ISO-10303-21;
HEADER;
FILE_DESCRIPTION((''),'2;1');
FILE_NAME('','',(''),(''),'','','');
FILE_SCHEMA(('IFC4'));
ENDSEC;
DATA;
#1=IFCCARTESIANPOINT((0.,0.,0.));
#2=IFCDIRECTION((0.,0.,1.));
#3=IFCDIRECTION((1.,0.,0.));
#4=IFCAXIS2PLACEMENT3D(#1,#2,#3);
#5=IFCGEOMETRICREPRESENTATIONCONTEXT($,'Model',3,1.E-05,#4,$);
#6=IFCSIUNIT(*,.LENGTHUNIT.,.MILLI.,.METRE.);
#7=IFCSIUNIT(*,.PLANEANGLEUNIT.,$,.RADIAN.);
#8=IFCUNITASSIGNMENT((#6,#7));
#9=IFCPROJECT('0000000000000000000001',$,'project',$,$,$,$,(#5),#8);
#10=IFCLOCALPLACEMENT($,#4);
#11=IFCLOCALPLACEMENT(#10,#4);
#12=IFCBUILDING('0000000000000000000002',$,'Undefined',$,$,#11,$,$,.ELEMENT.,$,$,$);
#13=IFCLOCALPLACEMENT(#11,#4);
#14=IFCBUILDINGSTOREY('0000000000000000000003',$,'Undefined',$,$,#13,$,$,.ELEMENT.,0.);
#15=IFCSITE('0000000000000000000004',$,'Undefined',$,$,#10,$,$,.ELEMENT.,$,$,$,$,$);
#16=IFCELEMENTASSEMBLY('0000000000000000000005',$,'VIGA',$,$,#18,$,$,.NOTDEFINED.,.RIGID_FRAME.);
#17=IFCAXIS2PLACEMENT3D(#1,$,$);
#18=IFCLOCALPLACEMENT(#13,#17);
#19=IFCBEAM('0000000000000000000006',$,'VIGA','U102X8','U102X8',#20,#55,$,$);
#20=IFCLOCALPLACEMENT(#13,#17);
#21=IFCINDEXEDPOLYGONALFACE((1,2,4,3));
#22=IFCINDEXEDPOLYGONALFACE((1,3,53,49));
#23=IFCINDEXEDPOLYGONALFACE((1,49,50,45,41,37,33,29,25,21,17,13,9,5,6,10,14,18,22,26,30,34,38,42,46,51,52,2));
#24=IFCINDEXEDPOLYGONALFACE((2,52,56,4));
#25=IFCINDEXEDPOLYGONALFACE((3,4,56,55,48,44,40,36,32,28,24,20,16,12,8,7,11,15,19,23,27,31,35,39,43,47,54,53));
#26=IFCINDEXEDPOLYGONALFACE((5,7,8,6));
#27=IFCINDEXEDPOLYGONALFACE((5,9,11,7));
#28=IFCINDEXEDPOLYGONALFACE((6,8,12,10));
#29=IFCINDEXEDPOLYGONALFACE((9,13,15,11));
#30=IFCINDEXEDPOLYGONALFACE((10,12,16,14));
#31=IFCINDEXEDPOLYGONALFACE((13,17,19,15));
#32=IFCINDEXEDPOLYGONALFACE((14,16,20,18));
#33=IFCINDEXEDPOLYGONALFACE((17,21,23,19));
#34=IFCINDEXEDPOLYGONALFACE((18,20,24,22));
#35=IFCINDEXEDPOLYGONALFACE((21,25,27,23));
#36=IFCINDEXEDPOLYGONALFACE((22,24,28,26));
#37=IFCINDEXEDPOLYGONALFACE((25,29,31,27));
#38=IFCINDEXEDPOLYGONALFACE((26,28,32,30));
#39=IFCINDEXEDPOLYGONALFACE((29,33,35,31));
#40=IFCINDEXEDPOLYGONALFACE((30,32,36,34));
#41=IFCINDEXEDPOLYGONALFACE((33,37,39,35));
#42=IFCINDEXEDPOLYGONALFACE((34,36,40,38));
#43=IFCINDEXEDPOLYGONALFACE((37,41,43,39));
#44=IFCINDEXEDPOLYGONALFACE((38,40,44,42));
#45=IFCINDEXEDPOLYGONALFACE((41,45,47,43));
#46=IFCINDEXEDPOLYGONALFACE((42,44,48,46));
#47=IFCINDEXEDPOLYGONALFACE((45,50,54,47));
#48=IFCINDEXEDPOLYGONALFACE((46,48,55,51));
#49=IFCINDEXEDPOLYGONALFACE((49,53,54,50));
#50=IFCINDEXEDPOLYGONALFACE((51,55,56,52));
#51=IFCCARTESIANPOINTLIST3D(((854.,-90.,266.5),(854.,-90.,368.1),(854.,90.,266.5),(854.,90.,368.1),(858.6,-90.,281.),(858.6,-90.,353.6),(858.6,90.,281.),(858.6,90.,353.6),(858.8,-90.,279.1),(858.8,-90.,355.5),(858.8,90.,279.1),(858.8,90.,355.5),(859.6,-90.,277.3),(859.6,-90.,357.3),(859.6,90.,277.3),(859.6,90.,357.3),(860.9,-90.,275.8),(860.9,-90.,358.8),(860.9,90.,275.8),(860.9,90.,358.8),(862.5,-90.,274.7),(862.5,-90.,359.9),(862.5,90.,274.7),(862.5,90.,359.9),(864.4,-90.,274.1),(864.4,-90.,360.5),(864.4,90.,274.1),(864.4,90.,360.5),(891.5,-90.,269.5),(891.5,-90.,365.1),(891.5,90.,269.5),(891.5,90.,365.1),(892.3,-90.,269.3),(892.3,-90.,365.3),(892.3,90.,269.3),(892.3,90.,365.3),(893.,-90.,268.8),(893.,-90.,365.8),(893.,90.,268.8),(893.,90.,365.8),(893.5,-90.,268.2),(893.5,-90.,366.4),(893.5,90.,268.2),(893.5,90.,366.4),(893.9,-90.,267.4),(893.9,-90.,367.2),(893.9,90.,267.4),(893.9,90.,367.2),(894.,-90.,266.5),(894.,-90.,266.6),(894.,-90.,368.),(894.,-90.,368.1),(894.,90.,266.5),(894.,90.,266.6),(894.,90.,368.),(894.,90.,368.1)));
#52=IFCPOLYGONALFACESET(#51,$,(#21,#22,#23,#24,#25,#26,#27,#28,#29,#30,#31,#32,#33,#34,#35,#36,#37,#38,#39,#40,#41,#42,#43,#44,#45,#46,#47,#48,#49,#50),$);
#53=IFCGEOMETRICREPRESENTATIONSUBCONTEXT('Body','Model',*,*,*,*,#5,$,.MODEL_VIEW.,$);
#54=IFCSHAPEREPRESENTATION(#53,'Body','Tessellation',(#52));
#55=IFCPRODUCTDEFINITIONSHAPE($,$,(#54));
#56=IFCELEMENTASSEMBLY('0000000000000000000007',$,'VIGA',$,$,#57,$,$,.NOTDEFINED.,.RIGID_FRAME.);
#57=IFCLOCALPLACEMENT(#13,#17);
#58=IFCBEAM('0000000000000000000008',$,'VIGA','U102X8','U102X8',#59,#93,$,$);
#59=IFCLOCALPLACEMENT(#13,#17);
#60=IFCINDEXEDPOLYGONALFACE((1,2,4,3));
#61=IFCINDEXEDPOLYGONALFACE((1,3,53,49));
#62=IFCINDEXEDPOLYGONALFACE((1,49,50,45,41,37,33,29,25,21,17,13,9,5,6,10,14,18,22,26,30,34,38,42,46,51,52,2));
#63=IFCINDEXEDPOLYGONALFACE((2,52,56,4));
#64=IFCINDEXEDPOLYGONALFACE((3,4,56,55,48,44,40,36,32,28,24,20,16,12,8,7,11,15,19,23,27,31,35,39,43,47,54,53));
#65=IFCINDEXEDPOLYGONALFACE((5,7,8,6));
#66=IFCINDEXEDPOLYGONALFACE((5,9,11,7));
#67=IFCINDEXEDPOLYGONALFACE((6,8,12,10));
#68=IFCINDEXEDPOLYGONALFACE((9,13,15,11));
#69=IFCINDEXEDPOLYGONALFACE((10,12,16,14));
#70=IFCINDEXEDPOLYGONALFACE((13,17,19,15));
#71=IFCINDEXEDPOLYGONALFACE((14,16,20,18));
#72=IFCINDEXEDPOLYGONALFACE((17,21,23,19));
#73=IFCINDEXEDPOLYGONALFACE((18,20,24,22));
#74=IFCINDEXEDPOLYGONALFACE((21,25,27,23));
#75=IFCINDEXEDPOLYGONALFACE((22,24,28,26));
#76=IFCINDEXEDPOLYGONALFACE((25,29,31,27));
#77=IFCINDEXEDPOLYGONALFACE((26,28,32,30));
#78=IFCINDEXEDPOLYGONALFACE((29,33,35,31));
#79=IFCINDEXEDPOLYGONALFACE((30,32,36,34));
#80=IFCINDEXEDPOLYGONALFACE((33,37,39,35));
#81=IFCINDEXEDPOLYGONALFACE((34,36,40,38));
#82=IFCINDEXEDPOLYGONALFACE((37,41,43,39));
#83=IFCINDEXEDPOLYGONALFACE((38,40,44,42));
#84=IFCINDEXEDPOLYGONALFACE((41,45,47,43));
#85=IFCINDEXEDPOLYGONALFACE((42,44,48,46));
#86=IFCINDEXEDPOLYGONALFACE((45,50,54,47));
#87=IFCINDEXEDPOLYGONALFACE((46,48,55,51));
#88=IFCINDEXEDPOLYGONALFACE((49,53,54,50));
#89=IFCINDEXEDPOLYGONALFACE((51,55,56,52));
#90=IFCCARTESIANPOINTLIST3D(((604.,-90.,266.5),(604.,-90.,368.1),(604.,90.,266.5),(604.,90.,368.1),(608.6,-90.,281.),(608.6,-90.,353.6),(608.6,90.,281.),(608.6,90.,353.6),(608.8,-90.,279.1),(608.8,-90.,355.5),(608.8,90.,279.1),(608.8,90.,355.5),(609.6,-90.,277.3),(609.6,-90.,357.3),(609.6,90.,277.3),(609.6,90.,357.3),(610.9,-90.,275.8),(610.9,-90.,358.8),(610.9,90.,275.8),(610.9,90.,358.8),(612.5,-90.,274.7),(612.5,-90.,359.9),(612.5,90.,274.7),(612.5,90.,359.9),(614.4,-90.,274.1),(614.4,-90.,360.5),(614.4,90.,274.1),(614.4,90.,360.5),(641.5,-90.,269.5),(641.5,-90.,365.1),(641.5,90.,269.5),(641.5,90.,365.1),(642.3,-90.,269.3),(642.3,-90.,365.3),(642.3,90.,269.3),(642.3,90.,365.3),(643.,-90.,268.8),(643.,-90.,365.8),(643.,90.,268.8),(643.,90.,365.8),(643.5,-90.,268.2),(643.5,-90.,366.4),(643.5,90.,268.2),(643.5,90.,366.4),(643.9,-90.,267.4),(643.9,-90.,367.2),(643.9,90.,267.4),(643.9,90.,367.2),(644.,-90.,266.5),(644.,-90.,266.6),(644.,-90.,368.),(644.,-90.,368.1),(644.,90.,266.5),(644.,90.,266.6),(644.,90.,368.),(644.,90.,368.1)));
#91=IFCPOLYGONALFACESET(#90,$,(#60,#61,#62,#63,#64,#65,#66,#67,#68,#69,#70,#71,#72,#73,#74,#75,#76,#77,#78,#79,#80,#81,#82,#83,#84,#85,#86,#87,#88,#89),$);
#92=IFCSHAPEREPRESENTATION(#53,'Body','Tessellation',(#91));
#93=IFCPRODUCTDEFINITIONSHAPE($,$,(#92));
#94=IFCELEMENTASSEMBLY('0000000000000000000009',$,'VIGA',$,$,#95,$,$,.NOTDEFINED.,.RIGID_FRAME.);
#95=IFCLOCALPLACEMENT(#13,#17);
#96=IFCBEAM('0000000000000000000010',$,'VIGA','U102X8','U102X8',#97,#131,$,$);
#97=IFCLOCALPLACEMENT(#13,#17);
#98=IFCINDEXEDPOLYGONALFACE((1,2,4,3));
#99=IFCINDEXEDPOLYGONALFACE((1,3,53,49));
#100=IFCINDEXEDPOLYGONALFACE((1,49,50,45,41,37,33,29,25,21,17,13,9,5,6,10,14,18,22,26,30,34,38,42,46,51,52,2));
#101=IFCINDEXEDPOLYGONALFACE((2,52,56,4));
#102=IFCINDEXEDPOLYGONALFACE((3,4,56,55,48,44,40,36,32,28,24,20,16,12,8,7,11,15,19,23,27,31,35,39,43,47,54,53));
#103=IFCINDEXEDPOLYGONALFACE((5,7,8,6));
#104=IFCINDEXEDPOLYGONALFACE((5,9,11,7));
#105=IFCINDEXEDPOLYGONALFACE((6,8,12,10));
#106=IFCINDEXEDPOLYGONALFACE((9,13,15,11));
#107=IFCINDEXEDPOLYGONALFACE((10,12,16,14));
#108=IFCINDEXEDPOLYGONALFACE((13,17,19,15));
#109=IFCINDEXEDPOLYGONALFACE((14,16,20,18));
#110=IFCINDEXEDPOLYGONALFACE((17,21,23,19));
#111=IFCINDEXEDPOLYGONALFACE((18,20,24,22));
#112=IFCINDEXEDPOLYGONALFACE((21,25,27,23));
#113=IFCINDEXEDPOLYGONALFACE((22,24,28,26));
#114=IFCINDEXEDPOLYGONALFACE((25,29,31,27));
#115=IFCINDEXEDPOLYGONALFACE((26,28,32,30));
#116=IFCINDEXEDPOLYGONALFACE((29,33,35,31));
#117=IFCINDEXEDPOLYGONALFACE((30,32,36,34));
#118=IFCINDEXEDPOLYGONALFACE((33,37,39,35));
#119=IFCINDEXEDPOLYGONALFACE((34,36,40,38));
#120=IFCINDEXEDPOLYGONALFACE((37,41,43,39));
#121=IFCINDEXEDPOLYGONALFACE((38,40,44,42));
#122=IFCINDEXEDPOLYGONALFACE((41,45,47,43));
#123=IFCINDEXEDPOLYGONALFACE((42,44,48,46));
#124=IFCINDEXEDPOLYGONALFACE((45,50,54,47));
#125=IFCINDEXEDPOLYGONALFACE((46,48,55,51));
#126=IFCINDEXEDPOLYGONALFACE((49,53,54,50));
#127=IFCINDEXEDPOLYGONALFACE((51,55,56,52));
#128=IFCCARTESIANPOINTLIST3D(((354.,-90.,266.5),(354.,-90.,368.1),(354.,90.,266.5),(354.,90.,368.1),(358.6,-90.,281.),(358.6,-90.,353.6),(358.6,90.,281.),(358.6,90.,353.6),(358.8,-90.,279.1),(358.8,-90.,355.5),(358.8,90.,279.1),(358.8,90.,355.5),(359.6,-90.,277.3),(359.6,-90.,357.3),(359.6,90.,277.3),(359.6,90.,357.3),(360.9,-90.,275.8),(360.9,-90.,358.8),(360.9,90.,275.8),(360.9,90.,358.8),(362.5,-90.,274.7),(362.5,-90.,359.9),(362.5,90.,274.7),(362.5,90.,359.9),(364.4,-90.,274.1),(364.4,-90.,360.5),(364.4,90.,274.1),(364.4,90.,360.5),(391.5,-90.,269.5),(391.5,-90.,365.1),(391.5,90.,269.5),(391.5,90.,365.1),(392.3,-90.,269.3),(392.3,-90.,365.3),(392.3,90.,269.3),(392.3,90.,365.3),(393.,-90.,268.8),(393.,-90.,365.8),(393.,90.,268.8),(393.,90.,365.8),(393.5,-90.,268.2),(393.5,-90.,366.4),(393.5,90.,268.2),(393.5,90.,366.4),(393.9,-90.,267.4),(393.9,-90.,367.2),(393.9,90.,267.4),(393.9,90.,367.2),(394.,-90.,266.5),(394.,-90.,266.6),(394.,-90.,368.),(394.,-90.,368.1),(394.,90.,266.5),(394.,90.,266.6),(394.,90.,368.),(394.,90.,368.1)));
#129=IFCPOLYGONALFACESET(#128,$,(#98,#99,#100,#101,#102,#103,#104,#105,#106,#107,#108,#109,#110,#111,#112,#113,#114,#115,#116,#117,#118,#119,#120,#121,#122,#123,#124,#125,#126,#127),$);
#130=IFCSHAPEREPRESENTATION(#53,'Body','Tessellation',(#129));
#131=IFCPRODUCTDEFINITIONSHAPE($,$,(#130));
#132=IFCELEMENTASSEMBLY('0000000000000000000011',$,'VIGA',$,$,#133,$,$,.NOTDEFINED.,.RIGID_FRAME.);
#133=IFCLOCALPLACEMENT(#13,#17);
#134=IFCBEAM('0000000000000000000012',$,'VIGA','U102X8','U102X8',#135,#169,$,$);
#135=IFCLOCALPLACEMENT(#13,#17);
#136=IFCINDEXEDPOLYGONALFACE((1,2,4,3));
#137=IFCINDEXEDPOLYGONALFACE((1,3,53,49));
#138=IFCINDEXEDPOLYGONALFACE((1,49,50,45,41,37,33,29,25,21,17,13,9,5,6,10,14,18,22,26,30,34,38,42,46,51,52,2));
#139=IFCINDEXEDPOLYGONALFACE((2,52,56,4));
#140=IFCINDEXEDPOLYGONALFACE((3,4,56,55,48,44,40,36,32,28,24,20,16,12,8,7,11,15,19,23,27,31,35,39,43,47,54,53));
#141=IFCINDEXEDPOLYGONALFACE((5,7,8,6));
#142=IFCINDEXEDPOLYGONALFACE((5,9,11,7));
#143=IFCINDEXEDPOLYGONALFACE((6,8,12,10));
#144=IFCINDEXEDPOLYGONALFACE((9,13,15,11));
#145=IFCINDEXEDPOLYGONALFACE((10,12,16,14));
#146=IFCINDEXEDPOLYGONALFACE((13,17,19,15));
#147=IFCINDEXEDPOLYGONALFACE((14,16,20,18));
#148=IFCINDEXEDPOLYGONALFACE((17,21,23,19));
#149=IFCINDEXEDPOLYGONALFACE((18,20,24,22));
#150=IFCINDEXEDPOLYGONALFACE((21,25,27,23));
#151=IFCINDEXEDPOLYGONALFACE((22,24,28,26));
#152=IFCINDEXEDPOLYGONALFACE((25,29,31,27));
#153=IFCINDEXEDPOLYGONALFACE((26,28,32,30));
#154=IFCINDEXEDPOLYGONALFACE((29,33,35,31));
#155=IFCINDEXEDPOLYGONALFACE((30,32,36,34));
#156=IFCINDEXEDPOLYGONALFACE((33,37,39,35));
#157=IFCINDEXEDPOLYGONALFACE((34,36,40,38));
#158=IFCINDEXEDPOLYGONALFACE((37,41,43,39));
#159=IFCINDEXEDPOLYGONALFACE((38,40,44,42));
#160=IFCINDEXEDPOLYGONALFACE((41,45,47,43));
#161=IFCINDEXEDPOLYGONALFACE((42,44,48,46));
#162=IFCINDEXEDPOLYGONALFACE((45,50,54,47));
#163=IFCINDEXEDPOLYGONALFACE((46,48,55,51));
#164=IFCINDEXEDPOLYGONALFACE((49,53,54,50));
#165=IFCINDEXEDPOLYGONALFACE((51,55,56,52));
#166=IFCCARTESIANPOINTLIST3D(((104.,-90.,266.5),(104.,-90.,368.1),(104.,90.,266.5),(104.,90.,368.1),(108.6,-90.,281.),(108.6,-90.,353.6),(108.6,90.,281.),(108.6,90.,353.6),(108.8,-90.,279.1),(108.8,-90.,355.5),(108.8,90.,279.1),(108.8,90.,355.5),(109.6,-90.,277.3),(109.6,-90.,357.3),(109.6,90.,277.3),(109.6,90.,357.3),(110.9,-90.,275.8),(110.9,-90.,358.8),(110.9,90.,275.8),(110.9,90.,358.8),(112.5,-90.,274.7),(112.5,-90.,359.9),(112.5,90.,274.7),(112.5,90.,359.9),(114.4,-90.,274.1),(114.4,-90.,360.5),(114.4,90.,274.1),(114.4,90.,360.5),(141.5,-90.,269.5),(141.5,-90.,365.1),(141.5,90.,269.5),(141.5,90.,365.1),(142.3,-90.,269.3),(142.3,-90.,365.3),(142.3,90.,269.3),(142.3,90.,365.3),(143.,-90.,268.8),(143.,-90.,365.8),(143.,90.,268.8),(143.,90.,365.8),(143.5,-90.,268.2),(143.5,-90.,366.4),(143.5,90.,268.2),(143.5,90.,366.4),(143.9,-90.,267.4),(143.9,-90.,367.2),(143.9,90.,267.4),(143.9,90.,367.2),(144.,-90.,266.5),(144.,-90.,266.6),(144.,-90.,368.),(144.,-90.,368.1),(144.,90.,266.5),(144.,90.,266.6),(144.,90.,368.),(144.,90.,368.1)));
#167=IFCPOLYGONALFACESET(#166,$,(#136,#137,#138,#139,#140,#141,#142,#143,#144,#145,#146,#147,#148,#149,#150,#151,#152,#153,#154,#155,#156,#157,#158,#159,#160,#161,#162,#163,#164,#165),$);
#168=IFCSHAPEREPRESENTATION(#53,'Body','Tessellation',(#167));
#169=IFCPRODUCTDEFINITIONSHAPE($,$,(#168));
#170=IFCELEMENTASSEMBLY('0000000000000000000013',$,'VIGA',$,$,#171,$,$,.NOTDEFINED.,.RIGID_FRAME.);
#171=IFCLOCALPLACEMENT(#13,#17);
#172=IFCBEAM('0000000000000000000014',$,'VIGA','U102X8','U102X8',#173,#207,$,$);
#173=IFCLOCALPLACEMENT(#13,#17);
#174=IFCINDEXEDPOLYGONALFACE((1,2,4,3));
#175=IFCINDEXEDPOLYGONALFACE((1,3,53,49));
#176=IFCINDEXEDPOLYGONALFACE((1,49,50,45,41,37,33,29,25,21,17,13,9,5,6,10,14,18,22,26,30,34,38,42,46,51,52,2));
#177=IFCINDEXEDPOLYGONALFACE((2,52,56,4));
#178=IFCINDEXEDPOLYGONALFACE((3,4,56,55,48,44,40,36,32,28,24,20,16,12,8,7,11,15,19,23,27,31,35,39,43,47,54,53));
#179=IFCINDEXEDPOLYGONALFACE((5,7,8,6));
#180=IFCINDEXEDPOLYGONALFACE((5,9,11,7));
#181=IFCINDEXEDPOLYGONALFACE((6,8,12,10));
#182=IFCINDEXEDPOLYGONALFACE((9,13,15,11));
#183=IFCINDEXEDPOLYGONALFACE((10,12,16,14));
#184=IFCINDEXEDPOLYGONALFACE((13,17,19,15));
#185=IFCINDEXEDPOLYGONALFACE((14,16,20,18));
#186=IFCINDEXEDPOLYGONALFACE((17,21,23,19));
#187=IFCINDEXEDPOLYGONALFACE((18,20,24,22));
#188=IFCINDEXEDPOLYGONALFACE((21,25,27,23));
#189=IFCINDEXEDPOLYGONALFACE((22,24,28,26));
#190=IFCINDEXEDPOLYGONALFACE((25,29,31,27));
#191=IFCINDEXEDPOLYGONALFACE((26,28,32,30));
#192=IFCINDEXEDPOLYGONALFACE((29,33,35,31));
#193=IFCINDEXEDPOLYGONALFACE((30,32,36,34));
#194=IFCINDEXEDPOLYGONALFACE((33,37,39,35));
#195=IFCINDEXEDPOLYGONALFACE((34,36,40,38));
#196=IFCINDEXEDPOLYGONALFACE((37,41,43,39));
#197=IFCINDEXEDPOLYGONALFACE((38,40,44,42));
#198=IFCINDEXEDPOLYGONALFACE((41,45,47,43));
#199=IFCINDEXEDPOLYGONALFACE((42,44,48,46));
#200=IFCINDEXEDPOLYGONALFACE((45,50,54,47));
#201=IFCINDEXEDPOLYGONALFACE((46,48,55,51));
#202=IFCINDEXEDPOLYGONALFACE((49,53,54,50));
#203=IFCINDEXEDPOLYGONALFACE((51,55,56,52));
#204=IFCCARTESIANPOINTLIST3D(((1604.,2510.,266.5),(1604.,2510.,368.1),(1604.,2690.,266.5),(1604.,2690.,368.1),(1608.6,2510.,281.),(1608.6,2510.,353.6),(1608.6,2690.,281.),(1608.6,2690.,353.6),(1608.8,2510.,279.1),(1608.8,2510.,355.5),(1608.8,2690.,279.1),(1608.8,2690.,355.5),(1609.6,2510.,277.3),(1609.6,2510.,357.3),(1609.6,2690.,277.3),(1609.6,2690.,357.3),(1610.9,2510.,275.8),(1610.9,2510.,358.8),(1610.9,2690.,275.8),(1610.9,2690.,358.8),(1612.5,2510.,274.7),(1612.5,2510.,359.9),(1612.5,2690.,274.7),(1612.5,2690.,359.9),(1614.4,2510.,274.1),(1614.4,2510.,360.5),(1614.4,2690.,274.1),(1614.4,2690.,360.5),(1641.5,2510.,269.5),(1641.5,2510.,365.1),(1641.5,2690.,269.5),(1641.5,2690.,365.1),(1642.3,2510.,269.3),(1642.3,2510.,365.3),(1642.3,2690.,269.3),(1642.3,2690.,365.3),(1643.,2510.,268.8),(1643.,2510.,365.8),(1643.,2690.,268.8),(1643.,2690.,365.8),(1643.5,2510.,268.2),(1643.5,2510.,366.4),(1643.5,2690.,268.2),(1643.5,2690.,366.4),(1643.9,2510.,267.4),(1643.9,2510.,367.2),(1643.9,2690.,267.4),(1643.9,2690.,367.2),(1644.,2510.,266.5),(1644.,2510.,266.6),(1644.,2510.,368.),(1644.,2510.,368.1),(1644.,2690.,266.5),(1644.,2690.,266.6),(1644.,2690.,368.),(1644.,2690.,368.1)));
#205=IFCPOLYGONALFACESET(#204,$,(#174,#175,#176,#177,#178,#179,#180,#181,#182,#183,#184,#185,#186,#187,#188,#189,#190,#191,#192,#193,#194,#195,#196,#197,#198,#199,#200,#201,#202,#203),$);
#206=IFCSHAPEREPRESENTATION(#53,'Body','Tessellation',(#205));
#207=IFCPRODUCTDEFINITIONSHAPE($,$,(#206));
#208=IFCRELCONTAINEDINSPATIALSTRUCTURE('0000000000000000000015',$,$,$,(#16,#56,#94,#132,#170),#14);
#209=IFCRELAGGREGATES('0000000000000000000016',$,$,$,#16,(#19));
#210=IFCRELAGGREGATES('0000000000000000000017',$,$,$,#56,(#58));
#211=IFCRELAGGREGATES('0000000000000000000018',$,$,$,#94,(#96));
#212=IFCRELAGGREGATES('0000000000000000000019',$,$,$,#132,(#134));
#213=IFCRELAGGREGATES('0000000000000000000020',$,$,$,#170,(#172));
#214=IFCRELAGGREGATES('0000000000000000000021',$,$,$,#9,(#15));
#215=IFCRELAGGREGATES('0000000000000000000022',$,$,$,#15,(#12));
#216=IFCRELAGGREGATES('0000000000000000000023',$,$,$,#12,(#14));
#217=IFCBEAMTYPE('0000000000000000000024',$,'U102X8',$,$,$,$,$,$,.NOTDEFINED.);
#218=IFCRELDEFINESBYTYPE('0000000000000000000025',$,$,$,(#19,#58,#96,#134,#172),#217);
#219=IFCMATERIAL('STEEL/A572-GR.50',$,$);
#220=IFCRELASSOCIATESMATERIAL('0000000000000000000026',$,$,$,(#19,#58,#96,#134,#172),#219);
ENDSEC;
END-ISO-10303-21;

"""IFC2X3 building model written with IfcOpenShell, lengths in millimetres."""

from ifc_helpers import new_model, si_unit, frame, origin_with_axes, origin_2d_with_axis, place, context, subcontext, project, spatial, u_section, extrude, material, type_object, element, aggregate, save


model = new_model("IFC2X3")

# Units and contexts
model_context = context("Model", 3, precision=1e-05, world=origin_with_axes())
body_context = subcontext(model_context, "Body", "Model", "MODEL_VIEW")
ifc_project = project(units=[si_unit("LENGTHUNIT", "METRE", prefix="MILLI"), si_unit("PLANEANGLEUNIT", "RADIAN")], contexts=[model_context])

# Site, building, storey
site_placement = place(None, origin_with_axes())
site = spatial("IfcSite", under=ifc_project, at=site_placement, Name="Undefined", CompositionType="ELEMENT")
building_placement = place(site_placement, origin_with_axes())
building = spatial("IfcBuilding", under=site, at=building_placement, Name="Undefined", CompositionType="ELEMENT")
storey_placement = place(building_placement, origin_with_axes())
storey = spatial("IfcBuildingStorey", under=building, at=storey_placement, Name="Undefined", CompositionType="ELEMENT", Elevation=0.0)

# Element assemblies, beams
ifc_material_1 = material(Name="STEEL/A572-GR.50")
beam_type_1 = type_object("IfcBeamType", Name="U102X8", PredefinedType="NOTDEFINED")
assembly_1_placement = place(storey_placement, origin_with_axes())
assembly_1 = element("IfcElementAssembly", 1, at=assembly_1_placement, inside=storey, Name="VIGA", AssemblyPlace="NOTDEFINED", PredefinedType="RIGID_FRAME")
beam_1_placement = place(assembly_1_placement, frame((874.0, -90.0, 317.3), z_axis=(0.0, 0.0, 1.0), x_axis=(0.0, 1.0, 0.0)))
beam_1 = element("IfcBeam", 2, at=beam_1_placement, type_object=beam_type_1, material=ifc_material_1, Name="VIGA", Description="U102X8", ObjectType="U102X8", context=body_context, shape_type="SweptSolid", body=[
    extrude(u_section(Depth=101.6, FlangeWidth=40.0, WebThickness=4.6, FlangeThickness=6.0, FilletRadius=7.0, EdgeRadius=3.0, FlangeSlope=0.16839, at=origin_2d_with_axis()), frame((180.0, 0.0, 0.0), z_axis=(-1.0, 0.0, 0.0), x_axis=(0.0, -1.0, 0.0)), (0.0, 0.0, 1.0), 180.0),
])
aggregate(assembly_1, [beam_1])
assembly_2_placement = place(storey_placement, origin_with_axes())
assembly_2 = element("IfcElementAssembly", 3, at=assembly_2_placement, inside=storey, Name="VIGA", AssemblyPlace="NOTDEFINED", PredefinedType="RIGID_FRAME")
beam_2_placement = place(assembly_2_placement, frame((624.0, -90.0, 317.3), z_axis=(0.0, 0.0, 1.0), x_axis=(0.0, 1.0, 0.0)))
beam_2 = element("IfcBeam", 4, at=beam_2_placement, type_object=beam_type_1, material=ifc_material_1, Name="VIGA", Description="U102X8", ObjectType="U102X8", context=body_context, shape_type="SweptSolid", body=[
    extrude(u_section(Depth=101.6, FlangeWidth=40.0, WebThickness=4.6, FlangeThickness=6.0, FilletRadius=7.0, EdgeRadius=3.0, FlangeSlope=0.16839, at=origin_2d_with_axis()), frame((180.0, 0.0, 0.0), z_axis=(-1.0, 0.0, 0.0), x_axis=(0.0, -1.0, 0.0)), (0.0, 0.0, 1.0), 180.0),
])
aggregate(assembly_2, [beam_2])
assembly_3_placement = place(storey_placement, origin_with_axes())
assembly_3 = element("IfcElementAssembly", 5, at=assembly_3_placement, inside=storey, Name="VIGA", AssemblyPlace="NOTDEFINED", PredefinedType="RIGID_FRAME")
beam_3_placement = place(assembly_3_placement, frame((374.0, -90.0, 317.3), z_axis=(0.0, 0.0, 1.0), x_axis=(0.0, 1.0, 0.0)))
beam_3 = element("IfcBeam", 6, at=beam_3_placement, type_object=beam_type_1, material=ifc_material_1, Name="VIGA", Description="U102X8", ObjectType="U102X8", context=body_context, shape_type="SweptSolid", body=[
    extrude(u_section(Depth=101.6, FlangeWidth=40.0, WebThickness=4.6, FlangeThickness=6.0, FilletRadius=7.0, EdgeRadius=3.0, FlangeSlope=0.16839, at=origin_2d_with_axis()), frame((180.0, 0.0, 0.0), z_axis=(-1.0, 0.0, 0.0), x_axis=(0.0, -1.0, 0.0)), (0.0, 0.0, 1.0), 180.0),
])
aggregate(assembly_3, [beam_3])
assembly_4_placement = place(storey_placement, origin_with_axes())
assembly_4 = element("IfcElementAssembly", 7, at=assembly_4_placement, inside=storey, Name="VIGA", AssemblyPlace="NOTDEFINED", PredefinedType="RIGID_FRAME")
beam_4_placement = place(assembly_4_placement, frame((124.0, -90.0, 317.3), z_axis=(0.0, 0.0, 1.0), x_axis=(0.0, 1.0, 0.0)))
beam_4 = element("IfcBeam", 8, at=beam_4_placement, type_object=beam_type_1, material=ifc_material_1, Name="VIGA", Description="U102X8", ObjectType="U102X8", context=body_context, shape_type="SweptSolid", body=[
    extrude(u_section(Depth=101.6, FlangeWidth=40.0, WebThickness=4.6, FlangeThickness=6.0, FilletRadius=7.0, EdgeRadius=3.0, FlangeSlope=0.16839, at=origin_2d_with_axis()), frame((180.0, 0.0, 0.0), z_axis=(-1.0, 0.0, 0.0), x_axis=(0.0, -1.0, 0.0)), (0.0, 0.0, 1.0), 180.0),
])
aggregate(assembly_4, [beam_4])
assembly_5_placement = place(storey_placement, origin_with_axes())
assembly_5 = element("IfcElementAssembly", 9, at=assembly_5_placement, inside=storey, Name="VIGA", AssemblyPlace="NOTDEFINED", PredefinedType="RIGID_FRAME")
beam_5_placement = place(assembly_5_placement, frame((1624.0, 2510.0, 317.3), z_axis=(0.0, 0.0, 1.0), x_axis=(0.0, 1.0, 0.0)))
beam_5 = element("IfcBeam", 10, at=beam_5_placement, type_object=beam_type_1, material=ifc_material_1, Name="VIGA", Description="U102X8", ObjectType="U102X8", context=body_context, shape_type="SweptSolid", body=[
    extrude(u_section(Depth=101.6, FlangeWidth=40.0, WebThickness=4.6, FlangeThickness=6.0, FilletRadius=7.0, EdgeRadius=3.0, FlangeSlope=0.16839, at=origin_2d_with_axis()), frame((180.0, 0.0, 0.0), z_axis=(-1.0, 0.0, 0.0), x_axis=(0.0, -1.0, 0.0)), (0.0, 0.0, 1.0), 180.0),
])
aggregate(assembly_5, [beam_5])

save(model, "model.ifc")
